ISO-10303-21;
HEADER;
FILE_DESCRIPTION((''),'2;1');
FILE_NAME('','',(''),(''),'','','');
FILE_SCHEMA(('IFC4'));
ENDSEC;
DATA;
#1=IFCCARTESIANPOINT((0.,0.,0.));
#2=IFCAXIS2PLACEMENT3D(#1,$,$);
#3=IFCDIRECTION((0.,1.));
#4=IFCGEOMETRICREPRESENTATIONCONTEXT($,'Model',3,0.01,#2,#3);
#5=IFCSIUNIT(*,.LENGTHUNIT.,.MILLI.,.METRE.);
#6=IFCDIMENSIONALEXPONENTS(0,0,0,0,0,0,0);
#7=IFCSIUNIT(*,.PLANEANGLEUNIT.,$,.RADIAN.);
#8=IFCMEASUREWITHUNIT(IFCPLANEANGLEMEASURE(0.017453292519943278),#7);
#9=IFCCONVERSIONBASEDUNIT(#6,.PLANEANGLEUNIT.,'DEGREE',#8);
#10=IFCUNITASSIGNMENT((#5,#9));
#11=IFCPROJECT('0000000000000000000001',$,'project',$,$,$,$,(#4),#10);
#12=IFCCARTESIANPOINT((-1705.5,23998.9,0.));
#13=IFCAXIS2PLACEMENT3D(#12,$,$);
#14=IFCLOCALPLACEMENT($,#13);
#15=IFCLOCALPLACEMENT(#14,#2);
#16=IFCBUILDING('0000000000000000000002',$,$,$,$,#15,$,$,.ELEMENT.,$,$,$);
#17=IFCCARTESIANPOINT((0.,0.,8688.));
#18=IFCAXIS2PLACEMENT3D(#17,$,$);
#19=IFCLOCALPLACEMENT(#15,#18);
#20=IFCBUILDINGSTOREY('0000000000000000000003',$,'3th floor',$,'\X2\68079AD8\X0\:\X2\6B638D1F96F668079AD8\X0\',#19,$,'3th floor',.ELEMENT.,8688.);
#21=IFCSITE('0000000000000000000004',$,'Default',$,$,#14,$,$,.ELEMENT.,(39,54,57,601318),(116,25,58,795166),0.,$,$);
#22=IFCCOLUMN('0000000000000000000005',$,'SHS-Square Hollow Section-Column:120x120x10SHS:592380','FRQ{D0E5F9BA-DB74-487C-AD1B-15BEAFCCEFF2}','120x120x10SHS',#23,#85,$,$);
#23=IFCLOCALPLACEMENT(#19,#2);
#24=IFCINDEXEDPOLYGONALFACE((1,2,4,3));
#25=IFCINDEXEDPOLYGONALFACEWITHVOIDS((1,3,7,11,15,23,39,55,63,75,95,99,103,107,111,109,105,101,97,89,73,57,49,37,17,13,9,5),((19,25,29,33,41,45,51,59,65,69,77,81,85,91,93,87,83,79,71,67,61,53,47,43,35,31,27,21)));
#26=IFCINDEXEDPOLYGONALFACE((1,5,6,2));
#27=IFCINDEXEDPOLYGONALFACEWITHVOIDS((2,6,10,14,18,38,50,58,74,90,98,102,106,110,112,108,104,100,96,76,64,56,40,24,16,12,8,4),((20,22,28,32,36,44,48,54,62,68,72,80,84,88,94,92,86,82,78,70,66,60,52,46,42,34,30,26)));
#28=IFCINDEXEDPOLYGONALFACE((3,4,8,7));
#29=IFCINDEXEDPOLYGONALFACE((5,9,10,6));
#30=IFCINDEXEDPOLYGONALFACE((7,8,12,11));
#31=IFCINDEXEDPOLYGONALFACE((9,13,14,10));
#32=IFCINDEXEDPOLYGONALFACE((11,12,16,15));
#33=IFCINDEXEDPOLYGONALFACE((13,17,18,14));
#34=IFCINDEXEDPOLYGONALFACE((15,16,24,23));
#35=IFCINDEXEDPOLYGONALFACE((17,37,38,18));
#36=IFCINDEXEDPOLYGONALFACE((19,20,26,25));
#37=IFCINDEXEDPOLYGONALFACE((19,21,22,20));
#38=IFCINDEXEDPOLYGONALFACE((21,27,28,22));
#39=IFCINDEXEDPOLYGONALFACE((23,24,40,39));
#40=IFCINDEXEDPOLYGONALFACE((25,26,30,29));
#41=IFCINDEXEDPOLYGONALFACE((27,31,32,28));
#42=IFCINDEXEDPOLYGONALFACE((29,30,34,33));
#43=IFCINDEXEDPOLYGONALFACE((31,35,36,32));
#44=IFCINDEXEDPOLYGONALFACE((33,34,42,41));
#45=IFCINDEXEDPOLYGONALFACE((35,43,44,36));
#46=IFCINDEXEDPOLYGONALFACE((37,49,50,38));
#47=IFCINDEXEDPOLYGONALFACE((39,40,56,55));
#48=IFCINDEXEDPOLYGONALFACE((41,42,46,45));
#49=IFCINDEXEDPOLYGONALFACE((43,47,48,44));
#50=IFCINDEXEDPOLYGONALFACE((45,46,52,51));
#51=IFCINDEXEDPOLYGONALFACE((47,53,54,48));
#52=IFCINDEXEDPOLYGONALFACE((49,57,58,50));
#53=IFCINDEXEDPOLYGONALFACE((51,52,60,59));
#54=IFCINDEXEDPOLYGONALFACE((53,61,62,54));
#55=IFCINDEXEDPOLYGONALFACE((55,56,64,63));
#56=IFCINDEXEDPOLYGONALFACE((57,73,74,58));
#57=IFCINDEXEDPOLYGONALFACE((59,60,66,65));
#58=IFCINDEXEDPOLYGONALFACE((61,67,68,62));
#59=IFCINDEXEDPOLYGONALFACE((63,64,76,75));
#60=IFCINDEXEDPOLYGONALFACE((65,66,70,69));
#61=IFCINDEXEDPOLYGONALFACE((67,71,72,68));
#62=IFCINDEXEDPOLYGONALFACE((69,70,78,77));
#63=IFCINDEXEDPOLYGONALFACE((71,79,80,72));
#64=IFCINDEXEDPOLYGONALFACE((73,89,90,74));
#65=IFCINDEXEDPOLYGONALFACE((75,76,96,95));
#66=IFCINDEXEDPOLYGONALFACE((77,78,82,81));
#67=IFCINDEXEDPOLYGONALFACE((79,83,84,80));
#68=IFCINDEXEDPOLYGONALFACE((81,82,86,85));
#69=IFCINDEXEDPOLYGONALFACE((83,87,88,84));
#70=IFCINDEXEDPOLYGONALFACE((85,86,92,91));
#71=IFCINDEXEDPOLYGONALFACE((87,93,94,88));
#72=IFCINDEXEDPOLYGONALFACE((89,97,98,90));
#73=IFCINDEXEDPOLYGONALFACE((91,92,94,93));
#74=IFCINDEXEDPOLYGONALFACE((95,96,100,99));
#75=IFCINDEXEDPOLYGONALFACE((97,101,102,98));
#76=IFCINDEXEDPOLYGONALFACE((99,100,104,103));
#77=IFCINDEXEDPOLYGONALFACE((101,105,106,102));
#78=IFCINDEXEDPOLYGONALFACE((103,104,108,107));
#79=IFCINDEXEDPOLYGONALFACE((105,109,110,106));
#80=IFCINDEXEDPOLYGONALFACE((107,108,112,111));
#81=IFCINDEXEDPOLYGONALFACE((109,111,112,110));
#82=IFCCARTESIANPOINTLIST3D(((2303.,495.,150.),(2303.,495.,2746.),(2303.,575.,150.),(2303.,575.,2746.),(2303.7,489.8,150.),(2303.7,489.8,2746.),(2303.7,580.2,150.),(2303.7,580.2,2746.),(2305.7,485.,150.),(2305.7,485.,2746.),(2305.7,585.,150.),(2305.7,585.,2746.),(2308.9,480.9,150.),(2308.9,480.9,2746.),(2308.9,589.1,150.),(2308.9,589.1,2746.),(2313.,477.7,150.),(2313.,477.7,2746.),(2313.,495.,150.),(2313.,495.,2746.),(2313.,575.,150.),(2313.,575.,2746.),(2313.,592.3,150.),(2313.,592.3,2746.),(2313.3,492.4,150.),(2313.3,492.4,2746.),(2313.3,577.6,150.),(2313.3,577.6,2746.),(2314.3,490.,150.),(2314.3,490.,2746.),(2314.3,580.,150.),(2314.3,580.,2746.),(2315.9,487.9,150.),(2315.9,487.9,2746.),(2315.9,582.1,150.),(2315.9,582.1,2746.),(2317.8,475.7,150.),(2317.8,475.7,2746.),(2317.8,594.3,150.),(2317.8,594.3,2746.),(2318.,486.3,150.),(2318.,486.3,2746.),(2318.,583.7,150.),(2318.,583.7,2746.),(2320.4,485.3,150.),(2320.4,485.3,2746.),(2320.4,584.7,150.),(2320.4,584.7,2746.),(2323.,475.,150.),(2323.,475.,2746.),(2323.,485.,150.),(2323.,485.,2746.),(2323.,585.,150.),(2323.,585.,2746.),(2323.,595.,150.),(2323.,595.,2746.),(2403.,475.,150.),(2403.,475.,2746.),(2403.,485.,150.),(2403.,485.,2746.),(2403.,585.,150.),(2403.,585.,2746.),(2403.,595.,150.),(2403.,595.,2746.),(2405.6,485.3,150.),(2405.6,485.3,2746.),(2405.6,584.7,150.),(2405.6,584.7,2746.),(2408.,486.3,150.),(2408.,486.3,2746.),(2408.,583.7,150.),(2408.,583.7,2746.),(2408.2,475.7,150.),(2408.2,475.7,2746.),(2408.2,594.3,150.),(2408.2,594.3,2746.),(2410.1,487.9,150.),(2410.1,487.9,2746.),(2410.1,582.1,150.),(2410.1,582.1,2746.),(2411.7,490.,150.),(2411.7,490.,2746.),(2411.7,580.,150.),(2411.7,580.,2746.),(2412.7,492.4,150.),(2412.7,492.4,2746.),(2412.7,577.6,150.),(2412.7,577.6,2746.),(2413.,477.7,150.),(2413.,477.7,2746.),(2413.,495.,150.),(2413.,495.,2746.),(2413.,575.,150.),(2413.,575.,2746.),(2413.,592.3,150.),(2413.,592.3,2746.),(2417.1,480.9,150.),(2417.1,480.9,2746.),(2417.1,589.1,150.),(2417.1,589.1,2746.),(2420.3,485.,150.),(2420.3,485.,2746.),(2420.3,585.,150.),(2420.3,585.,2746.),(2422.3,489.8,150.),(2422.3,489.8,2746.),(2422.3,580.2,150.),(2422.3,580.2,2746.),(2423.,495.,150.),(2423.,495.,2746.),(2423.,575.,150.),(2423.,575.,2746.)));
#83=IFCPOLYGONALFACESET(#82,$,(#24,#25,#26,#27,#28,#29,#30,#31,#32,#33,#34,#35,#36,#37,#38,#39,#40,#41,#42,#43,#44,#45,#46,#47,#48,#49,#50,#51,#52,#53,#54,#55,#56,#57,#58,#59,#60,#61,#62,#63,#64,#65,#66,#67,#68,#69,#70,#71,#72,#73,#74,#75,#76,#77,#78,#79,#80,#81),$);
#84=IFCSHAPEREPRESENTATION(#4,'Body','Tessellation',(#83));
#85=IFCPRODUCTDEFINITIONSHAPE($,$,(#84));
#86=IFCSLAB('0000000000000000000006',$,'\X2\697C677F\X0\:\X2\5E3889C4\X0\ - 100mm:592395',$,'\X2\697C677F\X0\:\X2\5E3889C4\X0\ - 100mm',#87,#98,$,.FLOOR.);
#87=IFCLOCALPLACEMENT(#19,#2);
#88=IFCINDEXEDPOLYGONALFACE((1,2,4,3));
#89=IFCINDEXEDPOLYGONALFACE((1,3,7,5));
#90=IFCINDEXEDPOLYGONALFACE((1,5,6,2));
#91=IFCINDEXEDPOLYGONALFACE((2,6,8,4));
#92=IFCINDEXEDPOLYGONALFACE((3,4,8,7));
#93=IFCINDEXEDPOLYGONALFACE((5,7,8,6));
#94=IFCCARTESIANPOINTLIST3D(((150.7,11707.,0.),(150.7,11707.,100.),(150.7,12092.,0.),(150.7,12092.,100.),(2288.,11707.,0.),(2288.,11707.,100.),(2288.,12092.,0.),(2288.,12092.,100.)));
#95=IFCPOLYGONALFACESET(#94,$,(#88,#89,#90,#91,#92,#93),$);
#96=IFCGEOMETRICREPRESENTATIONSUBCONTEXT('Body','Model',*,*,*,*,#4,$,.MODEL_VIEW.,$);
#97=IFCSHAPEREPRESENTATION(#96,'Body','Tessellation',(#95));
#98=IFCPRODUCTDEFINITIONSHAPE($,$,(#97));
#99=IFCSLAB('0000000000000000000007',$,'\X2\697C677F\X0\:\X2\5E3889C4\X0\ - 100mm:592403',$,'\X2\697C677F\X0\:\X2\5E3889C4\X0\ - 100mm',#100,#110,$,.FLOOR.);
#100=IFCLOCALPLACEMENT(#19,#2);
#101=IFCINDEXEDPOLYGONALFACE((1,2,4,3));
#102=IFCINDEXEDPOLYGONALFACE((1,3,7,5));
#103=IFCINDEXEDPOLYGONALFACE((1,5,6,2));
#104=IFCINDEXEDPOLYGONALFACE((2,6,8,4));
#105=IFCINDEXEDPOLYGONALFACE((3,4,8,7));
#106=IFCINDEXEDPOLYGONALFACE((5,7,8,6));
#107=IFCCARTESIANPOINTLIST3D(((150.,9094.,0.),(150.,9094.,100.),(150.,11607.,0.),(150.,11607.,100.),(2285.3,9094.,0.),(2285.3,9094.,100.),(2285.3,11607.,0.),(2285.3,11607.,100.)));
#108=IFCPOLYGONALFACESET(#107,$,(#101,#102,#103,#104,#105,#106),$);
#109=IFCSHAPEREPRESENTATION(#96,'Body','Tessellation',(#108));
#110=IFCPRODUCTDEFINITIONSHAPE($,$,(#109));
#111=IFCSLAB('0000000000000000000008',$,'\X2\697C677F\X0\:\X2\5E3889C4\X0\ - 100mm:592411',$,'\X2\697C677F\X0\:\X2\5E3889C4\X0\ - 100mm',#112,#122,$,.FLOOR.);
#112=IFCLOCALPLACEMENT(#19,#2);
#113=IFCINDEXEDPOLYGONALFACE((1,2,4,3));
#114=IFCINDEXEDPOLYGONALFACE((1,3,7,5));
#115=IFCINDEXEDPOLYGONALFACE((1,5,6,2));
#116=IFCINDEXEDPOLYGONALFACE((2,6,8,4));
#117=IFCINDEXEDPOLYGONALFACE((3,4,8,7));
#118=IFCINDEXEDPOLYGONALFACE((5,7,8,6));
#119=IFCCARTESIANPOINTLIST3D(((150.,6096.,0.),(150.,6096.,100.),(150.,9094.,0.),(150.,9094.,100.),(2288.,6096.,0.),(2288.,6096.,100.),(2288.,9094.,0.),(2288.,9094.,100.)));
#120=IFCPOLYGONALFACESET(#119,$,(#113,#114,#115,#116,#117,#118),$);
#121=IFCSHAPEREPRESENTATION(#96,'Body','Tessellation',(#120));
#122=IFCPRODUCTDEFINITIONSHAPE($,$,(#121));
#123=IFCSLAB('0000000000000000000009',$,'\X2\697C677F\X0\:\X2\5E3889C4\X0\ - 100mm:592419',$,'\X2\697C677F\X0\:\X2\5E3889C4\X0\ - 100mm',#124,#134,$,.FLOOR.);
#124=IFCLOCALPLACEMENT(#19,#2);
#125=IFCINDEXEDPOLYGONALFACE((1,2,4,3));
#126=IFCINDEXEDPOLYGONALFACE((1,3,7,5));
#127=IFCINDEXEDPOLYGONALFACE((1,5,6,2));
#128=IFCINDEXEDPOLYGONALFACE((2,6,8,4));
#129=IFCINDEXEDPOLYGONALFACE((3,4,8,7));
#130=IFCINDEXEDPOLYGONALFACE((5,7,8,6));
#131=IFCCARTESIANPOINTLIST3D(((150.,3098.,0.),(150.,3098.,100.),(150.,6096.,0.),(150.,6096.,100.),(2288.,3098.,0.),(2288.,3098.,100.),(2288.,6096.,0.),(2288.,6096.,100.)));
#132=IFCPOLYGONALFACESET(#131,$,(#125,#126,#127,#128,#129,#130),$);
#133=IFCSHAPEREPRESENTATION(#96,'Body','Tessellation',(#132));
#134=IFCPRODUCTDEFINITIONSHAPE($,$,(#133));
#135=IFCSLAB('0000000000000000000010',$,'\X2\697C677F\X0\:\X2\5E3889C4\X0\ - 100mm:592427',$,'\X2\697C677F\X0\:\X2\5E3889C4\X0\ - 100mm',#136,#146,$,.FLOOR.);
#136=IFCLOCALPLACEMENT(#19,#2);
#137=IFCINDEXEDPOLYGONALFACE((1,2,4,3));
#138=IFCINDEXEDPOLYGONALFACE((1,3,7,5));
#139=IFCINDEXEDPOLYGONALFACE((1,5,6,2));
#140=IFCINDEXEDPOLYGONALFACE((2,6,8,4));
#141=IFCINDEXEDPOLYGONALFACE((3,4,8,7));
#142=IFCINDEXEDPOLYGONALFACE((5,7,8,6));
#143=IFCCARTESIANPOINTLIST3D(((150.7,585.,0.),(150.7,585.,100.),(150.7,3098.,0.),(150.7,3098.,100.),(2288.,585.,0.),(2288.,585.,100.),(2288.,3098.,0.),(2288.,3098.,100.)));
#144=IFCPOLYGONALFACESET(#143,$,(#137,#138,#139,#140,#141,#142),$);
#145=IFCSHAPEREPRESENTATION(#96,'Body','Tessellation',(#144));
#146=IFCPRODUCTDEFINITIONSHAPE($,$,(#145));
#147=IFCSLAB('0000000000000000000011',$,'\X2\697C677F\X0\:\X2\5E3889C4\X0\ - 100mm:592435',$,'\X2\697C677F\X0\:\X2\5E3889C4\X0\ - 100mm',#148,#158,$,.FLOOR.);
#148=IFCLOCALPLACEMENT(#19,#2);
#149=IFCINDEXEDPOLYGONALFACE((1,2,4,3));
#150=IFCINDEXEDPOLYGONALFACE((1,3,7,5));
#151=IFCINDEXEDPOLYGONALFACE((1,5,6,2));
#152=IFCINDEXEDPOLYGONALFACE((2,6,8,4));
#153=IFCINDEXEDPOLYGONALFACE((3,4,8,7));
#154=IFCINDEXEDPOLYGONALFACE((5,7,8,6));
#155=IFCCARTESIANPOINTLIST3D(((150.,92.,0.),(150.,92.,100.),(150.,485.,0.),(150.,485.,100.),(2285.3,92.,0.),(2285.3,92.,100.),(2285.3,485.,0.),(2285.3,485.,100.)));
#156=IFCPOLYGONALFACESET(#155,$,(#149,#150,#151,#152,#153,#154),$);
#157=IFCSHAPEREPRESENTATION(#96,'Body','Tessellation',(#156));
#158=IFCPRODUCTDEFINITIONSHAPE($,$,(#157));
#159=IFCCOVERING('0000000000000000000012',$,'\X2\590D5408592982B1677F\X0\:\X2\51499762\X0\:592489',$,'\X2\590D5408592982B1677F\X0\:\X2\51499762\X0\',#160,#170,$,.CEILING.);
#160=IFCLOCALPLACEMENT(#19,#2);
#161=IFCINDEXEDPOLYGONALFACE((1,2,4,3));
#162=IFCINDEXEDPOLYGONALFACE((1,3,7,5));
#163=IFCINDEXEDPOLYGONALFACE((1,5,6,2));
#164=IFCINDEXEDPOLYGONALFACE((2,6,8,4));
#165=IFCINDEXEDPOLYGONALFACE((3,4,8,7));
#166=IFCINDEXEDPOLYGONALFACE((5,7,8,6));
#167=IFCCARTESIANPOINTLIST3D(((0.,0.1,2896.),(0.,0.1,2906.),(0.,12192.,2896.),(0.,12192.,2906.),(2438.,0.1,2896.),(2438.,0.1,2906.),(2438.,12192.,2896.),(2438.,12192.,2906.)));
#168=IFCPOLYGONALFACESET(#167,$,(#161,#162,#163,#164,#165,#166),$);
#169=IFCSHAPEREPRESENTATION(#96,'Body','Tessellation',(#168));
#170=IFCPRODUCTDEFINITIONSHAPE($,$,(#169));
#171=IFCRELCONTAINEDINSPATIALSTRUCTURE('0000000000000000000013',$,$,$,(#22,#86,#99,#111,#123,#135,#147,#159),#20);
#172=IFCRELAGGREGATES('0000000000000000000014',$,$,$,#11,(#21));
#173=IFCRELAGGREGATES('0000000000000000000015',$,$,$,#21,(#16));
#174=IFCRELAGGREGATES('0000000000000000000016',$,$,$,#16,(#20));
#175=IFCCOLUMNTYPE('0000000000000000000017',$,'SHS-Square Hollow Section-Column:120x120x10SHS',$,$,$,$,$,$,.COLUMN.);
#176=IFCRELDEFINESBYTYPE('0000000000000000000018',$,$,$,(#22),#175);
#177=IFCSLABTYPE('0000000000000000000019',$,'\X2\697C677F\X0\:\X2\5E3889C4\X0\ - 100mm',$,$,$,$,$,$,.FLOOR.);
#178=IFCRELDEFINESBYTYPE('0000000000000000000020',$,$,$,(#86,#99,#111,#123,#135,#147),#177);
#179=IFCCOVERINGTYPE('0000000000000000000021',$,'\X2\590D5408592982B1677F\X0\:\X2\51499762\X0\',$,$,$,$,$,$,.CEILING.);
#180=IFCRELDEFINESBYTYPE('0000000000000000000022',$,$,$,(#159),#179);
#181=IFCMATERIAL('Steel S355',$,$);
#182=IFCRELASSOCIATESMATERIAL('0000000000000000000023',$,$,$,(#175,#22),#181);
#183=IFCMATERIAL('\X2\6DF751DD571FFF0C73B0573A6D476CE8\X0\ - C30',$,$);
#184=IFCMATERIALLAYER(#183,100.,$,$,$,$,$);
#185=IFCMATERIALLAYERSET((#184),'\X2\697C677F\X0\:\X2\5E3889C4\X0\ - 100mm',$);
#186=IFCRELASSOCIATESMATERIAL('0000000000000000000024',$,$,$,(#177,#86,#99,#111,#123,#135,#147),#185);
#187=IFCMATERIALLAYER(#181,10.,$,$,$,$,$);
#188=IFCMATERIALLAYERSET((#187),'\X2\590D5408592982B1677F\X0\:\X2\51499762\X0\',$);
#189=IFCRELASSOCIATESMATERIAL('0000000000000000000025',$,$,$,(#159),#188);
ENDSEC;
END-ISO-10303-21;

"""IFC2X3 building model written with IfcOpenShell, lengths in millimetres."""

from ifc_helpers import new_model, entity, si_unit, converted_unit, direction, frame, frame_2d, origin, origin_2d, origin_2d_with_axis, place, context, subcontext, project, spatial, rectangle, hollow_rectangle, extrude, clip, halfspace, material, layer, layer_set, layer_usage, type_object, element, save


model = new_model("IFC2X3")

# Units and contexts
model_context = context("Model", 3, precision=0.01, world=origin(), true_north=direction((0.0, 1.0)))
body_context = subcontext(model_context, "Body", "Model", "MODEL_VIEW")
ifc_project = project(units=[si_unit("LENGTHUNIT", "METRE", prefix="MILLI"), converted_unit("PLANEANGLEUNIT", "DEGREE", entity("IfcPlaneAngleMeasure", 0.017453292519943278), si_unit("PLANEANGLEUNIT", "RADIAN"), dimensions=[0, 0, 0, 0, 0, 0, 0])], contexts=[model_context])

# Site, building, storey
site_placement = place(None, frame((-1705.5, 23998.9, 0.0)))
site = spatial("IfcSite", under=ifc_project, at=site_placement, Name="Default", CompositionType="ELEMENT", RefLatitude=(39, 54, 57, 601318), RefLongitude=(116, 25, 58, 795166), RefElevation=0.0)
building_placement = place(site_placement, origin())
building = spatial("IfcBuilding", under=site, at=building_placement, CompositionType="ELEMENT")
storey_placement = place(building_placement, frame((0.0, 0.0, 8688.0)))
storey = spatial("IfcBuildingStorey", under=building, at=storey_placement, Name="3th floor", ObjectType="标高:正负零标高", LongName="3th floor", CompositionType="ELEMENT", Elevation=8688.0)

# Shared definitions
ifc_material_1 = material(Name="Steel S355")

# Column
column_type_1 = type_object("IfcColumnType", Name="SHS-Square Hollow Section-Column:120x120x10SHS", PredefinedType="COLUMN", material=ifc_material_1)
column_1_placement = place(storey_placement, frame((2363.0, 535.0, 2746.0), z_axis=(0.0, 0.0, 1.0), x_axis=(0.0, -1.0, 0.0)))
element("IfcColumn", 1, at=column_1_placement, inside=storey, type_object=column_type_1, material=ifc_material_1, Name="SHS-Square Hollow Section-Column:120x120x10SHS:592380", Description="FRQ{D0E5F9BA-DB74-487C-AD1B-15BEAFCCEFF2}", ObjectType="120x120x10SHS", context=model_context, shape_type="Clipping", body=[
    clip(extrude(hollow_rectangle(XDim=120.0, YDim=120.0, WallThickness=10.0, InnerFilletRadius=10.0, OuterFilletRadius=20.0, at=origin_2d()), origin(), (0.0, 0.0, -1.0), 2680.9), halfspace(frame((535.0, -2363.0, -2596.0), z_axis=(0.0, 0.0, 1.0), x_axis=(0.0, 1.0, 0.0)), True)),
])

# Slabs
ifc_material_2 = material(Name="混凝土，现场浇注 - C30")
ifc_layer_1 = layer(ifc_material_2, 100.0)
ifc_layer_set_1 = layer_set([ifc_layer_1], Name="楼板:常规 - 100mm")
ifc_layer_usage_1 = layer_usage(ifc_layer_set_1, "AXIS3", "POSITIVE", 0.0)
slab_type = type_object("IfcSlabType", Name="楼板:常规 - 100mm", PredefinedType="FLOOR", material=ifc_layer_set_1)
slab_1_placement = place(storey_placement, origin())
element("IfcSlab", 2, at=slab_1_placement, inside=storey, type_object=slab_type, material=ifc_layer_usage_1, Name="楼板:常规 - 100mm:592395", ObjectType="楼板:常规 - 100mm", PredefinedType="FLOOR", context=body_context, shape_type="SweptSolid", body=[
    extrude(rectangle(XDim=385.0, YDim=2137.3, at=origin_2d_with_axis()), frame((1219.3, 11899.5, 100.0), z_axis=(0.0, 0.0, -1.0), x_axis=(0.0, 1.0, 0.0)), (0.0, 0.0, 1.0), 100.0),
])
ifc_layer_usage_2 = layer_usage(ifc_layer_set_1, "AXIS3", "POSITIVE", 0.0)
slab_2_placement = place(storey_placement, origin())
element("IfcSlab", 3, at=slab_2_placement, inside=storey, type_object=slab_type, material=ifc_layer_usage_2, Name="楼板:常规 - 100mm:592403", ObjectType="楼板:常规 - 100mm", PredefinedType="FLOOR", context=body_context, shape_type="SweptSolid", body=[
    extrude(rectangle(XDim=2513.0, YDim=2135.3, at=frame_2d((0.0, 0.0), x_axis=(1.0, 0.0))), frame((1217.7, 10350.5, 100.0), z_axis=(0.0, 0.0, -1.0), x_axis=(0.0, 1.0, 0.0)), (0.0, 0.0, 1.0), 100.0),
])
ifc_layer_usage_3 = layer_usage(ifc_layer_set_1, "AXIS3", "POSITIVE", 0.0)
slab_3_placement = place(storey_placement, origin())
element("IfcSlab", 4, at=slab_3_placement, inside=storey, type_object=slab_type, material=ifc_layer_usage_3, Name="楼板:常规 - 100mm:592411", ObjectType="楼板:常规 - 100mm", PredefinedType="FLOOR", context=body_context, shape_type="SweptSolid", body=[
    extrude(rectangle(XDim=2998.0, YDim=2138.0, at=origin_2d_with_axis()), frame((1219.0, 7595.0, 100.0), z_axis=(0.0, 0.0, -1.0), x_axis=(0.0, 1.0, 0.0)), (0.0, 0.0, 1.0), 100.0),
])
ifc_layer_usage_4 = layer_usage(ifc_layer_set_1, "AXIS3", "POSITIVE", 0.0)
slab_4_placement = place(storey_placement, origin())
element("IfcSlab", 5, at=slab_4_placement, inside=storey, type_object=slab_type, material=ifc_layer_usage_4, Name="楼板:常规 - 100mm:592419", ObjectType="楼板:常规 - 100mm", PredefinedType="FLOOR", context=body_context, shape_type="SweptSolid", body=[
    extrude(rectangle(XDim=2998.0, YDim=2138.0, at=origin_2d_with_axis()), frame((1219.0, 4597.0, 100.0), z_axis=(0.0, 0.0, -1.0), x_axis=(0.0, 1.0, 0.0)), (0.0, 0.0, 1.0), 100.0),
])
ifc_layer_usage_5 = layer_usage(ifc_layer_set_1, "AXIS3", "POSITIVE", 0.0)
slab_5_placement = place(storey_placement, origin())
element("IfcSlab", 6, at=slab_5_placement, inside=storey, type_object=slab_type, material=ifc_layer_usage_5, Name="楼板:常规 - 100mm:592427", ObjectType="楼板:常规 - 100mm", PredefinedType="FLOOR", context=body_context, shape_type="SweptSolid", body=[
    extrude(rectangle(XDim=2513.0, YDim=2137.3, at=frame_2d((0.0, 0.0), x_axis=(1.0, 0.0))), frame((1219.3, 1841.5, 100.0), z_axis=(0.0, 0.0, -1.0), x_axis=(0.0, 1.0, 0.0)), (0.0, 0.0, 1.0), 100.0),
])
ifc_layer_usage_6 = layer_usage(ifc_layer_set_1, "AXIS3", "POSITIVE", 0.0)
slab_6_placement = place(storey_placement, origin())
element("IfcSlab", 7, at=slab_6_placement, inside=storey, type_object=slab_type, material=ifc_layer_usage_6, Name="楼板:常规 - 100mm:592435", ObjectType="楼板:常规 - 100mm", PredefinedType="FLOOR", context=body_context, shape_type="SweptSolid", body=[
    extrude(rectangle(XDim=393.0, YDim=2135.3, at=frame_2d((0.0, 0.0), x_axis=(1.0, 0.0))), frame((1217.7, 288.5, 100.0), z_axis=(0.0, 0.0, -1.0), x_axis=(0.0, 1.0, 0.0)), (0.0, 0.0, 1.0), 100.0),
])

# Covering
ifc_layer_2 = layer(ifc_material_1, 10.0)
ifc_layer_set_2 = layer_set([ifc_layer_2], Name="复合天花板:光面")
ifc_layer_usage_7 = layer_usage(ifc_layer_set_2, "AXIS3", "NEGATIVE", 10.0)
covering_type = type_object("IfcCoveringType", Name="复合天花板:光面", PredefinedType="CEILING")
covering_placement = place(storey_placement, origin())
element("IfcCovering", 8, at=covering_placement, inside=storey, type_object=covering_type, material=ifc_layer_usage_7, Name="复合天花板:光面:592489", ObjectType="复合天花板:光面", PredefinedType="CEILING", context=body_context, shape_type="SweptSolid", body=[
    extrude(rectangle(XDim=12191.9, YDim=2438.0, at=origin_2d_with_axis()), frame((1219.0, 6096.0, 2896.0), z_axis=(0.0, 0.0, 1.0), x_axis=(0.0, 1.0, 0.0)), (0.0, 0.0, 1.0), 10.0),
])

save(model, "model.ifc")
